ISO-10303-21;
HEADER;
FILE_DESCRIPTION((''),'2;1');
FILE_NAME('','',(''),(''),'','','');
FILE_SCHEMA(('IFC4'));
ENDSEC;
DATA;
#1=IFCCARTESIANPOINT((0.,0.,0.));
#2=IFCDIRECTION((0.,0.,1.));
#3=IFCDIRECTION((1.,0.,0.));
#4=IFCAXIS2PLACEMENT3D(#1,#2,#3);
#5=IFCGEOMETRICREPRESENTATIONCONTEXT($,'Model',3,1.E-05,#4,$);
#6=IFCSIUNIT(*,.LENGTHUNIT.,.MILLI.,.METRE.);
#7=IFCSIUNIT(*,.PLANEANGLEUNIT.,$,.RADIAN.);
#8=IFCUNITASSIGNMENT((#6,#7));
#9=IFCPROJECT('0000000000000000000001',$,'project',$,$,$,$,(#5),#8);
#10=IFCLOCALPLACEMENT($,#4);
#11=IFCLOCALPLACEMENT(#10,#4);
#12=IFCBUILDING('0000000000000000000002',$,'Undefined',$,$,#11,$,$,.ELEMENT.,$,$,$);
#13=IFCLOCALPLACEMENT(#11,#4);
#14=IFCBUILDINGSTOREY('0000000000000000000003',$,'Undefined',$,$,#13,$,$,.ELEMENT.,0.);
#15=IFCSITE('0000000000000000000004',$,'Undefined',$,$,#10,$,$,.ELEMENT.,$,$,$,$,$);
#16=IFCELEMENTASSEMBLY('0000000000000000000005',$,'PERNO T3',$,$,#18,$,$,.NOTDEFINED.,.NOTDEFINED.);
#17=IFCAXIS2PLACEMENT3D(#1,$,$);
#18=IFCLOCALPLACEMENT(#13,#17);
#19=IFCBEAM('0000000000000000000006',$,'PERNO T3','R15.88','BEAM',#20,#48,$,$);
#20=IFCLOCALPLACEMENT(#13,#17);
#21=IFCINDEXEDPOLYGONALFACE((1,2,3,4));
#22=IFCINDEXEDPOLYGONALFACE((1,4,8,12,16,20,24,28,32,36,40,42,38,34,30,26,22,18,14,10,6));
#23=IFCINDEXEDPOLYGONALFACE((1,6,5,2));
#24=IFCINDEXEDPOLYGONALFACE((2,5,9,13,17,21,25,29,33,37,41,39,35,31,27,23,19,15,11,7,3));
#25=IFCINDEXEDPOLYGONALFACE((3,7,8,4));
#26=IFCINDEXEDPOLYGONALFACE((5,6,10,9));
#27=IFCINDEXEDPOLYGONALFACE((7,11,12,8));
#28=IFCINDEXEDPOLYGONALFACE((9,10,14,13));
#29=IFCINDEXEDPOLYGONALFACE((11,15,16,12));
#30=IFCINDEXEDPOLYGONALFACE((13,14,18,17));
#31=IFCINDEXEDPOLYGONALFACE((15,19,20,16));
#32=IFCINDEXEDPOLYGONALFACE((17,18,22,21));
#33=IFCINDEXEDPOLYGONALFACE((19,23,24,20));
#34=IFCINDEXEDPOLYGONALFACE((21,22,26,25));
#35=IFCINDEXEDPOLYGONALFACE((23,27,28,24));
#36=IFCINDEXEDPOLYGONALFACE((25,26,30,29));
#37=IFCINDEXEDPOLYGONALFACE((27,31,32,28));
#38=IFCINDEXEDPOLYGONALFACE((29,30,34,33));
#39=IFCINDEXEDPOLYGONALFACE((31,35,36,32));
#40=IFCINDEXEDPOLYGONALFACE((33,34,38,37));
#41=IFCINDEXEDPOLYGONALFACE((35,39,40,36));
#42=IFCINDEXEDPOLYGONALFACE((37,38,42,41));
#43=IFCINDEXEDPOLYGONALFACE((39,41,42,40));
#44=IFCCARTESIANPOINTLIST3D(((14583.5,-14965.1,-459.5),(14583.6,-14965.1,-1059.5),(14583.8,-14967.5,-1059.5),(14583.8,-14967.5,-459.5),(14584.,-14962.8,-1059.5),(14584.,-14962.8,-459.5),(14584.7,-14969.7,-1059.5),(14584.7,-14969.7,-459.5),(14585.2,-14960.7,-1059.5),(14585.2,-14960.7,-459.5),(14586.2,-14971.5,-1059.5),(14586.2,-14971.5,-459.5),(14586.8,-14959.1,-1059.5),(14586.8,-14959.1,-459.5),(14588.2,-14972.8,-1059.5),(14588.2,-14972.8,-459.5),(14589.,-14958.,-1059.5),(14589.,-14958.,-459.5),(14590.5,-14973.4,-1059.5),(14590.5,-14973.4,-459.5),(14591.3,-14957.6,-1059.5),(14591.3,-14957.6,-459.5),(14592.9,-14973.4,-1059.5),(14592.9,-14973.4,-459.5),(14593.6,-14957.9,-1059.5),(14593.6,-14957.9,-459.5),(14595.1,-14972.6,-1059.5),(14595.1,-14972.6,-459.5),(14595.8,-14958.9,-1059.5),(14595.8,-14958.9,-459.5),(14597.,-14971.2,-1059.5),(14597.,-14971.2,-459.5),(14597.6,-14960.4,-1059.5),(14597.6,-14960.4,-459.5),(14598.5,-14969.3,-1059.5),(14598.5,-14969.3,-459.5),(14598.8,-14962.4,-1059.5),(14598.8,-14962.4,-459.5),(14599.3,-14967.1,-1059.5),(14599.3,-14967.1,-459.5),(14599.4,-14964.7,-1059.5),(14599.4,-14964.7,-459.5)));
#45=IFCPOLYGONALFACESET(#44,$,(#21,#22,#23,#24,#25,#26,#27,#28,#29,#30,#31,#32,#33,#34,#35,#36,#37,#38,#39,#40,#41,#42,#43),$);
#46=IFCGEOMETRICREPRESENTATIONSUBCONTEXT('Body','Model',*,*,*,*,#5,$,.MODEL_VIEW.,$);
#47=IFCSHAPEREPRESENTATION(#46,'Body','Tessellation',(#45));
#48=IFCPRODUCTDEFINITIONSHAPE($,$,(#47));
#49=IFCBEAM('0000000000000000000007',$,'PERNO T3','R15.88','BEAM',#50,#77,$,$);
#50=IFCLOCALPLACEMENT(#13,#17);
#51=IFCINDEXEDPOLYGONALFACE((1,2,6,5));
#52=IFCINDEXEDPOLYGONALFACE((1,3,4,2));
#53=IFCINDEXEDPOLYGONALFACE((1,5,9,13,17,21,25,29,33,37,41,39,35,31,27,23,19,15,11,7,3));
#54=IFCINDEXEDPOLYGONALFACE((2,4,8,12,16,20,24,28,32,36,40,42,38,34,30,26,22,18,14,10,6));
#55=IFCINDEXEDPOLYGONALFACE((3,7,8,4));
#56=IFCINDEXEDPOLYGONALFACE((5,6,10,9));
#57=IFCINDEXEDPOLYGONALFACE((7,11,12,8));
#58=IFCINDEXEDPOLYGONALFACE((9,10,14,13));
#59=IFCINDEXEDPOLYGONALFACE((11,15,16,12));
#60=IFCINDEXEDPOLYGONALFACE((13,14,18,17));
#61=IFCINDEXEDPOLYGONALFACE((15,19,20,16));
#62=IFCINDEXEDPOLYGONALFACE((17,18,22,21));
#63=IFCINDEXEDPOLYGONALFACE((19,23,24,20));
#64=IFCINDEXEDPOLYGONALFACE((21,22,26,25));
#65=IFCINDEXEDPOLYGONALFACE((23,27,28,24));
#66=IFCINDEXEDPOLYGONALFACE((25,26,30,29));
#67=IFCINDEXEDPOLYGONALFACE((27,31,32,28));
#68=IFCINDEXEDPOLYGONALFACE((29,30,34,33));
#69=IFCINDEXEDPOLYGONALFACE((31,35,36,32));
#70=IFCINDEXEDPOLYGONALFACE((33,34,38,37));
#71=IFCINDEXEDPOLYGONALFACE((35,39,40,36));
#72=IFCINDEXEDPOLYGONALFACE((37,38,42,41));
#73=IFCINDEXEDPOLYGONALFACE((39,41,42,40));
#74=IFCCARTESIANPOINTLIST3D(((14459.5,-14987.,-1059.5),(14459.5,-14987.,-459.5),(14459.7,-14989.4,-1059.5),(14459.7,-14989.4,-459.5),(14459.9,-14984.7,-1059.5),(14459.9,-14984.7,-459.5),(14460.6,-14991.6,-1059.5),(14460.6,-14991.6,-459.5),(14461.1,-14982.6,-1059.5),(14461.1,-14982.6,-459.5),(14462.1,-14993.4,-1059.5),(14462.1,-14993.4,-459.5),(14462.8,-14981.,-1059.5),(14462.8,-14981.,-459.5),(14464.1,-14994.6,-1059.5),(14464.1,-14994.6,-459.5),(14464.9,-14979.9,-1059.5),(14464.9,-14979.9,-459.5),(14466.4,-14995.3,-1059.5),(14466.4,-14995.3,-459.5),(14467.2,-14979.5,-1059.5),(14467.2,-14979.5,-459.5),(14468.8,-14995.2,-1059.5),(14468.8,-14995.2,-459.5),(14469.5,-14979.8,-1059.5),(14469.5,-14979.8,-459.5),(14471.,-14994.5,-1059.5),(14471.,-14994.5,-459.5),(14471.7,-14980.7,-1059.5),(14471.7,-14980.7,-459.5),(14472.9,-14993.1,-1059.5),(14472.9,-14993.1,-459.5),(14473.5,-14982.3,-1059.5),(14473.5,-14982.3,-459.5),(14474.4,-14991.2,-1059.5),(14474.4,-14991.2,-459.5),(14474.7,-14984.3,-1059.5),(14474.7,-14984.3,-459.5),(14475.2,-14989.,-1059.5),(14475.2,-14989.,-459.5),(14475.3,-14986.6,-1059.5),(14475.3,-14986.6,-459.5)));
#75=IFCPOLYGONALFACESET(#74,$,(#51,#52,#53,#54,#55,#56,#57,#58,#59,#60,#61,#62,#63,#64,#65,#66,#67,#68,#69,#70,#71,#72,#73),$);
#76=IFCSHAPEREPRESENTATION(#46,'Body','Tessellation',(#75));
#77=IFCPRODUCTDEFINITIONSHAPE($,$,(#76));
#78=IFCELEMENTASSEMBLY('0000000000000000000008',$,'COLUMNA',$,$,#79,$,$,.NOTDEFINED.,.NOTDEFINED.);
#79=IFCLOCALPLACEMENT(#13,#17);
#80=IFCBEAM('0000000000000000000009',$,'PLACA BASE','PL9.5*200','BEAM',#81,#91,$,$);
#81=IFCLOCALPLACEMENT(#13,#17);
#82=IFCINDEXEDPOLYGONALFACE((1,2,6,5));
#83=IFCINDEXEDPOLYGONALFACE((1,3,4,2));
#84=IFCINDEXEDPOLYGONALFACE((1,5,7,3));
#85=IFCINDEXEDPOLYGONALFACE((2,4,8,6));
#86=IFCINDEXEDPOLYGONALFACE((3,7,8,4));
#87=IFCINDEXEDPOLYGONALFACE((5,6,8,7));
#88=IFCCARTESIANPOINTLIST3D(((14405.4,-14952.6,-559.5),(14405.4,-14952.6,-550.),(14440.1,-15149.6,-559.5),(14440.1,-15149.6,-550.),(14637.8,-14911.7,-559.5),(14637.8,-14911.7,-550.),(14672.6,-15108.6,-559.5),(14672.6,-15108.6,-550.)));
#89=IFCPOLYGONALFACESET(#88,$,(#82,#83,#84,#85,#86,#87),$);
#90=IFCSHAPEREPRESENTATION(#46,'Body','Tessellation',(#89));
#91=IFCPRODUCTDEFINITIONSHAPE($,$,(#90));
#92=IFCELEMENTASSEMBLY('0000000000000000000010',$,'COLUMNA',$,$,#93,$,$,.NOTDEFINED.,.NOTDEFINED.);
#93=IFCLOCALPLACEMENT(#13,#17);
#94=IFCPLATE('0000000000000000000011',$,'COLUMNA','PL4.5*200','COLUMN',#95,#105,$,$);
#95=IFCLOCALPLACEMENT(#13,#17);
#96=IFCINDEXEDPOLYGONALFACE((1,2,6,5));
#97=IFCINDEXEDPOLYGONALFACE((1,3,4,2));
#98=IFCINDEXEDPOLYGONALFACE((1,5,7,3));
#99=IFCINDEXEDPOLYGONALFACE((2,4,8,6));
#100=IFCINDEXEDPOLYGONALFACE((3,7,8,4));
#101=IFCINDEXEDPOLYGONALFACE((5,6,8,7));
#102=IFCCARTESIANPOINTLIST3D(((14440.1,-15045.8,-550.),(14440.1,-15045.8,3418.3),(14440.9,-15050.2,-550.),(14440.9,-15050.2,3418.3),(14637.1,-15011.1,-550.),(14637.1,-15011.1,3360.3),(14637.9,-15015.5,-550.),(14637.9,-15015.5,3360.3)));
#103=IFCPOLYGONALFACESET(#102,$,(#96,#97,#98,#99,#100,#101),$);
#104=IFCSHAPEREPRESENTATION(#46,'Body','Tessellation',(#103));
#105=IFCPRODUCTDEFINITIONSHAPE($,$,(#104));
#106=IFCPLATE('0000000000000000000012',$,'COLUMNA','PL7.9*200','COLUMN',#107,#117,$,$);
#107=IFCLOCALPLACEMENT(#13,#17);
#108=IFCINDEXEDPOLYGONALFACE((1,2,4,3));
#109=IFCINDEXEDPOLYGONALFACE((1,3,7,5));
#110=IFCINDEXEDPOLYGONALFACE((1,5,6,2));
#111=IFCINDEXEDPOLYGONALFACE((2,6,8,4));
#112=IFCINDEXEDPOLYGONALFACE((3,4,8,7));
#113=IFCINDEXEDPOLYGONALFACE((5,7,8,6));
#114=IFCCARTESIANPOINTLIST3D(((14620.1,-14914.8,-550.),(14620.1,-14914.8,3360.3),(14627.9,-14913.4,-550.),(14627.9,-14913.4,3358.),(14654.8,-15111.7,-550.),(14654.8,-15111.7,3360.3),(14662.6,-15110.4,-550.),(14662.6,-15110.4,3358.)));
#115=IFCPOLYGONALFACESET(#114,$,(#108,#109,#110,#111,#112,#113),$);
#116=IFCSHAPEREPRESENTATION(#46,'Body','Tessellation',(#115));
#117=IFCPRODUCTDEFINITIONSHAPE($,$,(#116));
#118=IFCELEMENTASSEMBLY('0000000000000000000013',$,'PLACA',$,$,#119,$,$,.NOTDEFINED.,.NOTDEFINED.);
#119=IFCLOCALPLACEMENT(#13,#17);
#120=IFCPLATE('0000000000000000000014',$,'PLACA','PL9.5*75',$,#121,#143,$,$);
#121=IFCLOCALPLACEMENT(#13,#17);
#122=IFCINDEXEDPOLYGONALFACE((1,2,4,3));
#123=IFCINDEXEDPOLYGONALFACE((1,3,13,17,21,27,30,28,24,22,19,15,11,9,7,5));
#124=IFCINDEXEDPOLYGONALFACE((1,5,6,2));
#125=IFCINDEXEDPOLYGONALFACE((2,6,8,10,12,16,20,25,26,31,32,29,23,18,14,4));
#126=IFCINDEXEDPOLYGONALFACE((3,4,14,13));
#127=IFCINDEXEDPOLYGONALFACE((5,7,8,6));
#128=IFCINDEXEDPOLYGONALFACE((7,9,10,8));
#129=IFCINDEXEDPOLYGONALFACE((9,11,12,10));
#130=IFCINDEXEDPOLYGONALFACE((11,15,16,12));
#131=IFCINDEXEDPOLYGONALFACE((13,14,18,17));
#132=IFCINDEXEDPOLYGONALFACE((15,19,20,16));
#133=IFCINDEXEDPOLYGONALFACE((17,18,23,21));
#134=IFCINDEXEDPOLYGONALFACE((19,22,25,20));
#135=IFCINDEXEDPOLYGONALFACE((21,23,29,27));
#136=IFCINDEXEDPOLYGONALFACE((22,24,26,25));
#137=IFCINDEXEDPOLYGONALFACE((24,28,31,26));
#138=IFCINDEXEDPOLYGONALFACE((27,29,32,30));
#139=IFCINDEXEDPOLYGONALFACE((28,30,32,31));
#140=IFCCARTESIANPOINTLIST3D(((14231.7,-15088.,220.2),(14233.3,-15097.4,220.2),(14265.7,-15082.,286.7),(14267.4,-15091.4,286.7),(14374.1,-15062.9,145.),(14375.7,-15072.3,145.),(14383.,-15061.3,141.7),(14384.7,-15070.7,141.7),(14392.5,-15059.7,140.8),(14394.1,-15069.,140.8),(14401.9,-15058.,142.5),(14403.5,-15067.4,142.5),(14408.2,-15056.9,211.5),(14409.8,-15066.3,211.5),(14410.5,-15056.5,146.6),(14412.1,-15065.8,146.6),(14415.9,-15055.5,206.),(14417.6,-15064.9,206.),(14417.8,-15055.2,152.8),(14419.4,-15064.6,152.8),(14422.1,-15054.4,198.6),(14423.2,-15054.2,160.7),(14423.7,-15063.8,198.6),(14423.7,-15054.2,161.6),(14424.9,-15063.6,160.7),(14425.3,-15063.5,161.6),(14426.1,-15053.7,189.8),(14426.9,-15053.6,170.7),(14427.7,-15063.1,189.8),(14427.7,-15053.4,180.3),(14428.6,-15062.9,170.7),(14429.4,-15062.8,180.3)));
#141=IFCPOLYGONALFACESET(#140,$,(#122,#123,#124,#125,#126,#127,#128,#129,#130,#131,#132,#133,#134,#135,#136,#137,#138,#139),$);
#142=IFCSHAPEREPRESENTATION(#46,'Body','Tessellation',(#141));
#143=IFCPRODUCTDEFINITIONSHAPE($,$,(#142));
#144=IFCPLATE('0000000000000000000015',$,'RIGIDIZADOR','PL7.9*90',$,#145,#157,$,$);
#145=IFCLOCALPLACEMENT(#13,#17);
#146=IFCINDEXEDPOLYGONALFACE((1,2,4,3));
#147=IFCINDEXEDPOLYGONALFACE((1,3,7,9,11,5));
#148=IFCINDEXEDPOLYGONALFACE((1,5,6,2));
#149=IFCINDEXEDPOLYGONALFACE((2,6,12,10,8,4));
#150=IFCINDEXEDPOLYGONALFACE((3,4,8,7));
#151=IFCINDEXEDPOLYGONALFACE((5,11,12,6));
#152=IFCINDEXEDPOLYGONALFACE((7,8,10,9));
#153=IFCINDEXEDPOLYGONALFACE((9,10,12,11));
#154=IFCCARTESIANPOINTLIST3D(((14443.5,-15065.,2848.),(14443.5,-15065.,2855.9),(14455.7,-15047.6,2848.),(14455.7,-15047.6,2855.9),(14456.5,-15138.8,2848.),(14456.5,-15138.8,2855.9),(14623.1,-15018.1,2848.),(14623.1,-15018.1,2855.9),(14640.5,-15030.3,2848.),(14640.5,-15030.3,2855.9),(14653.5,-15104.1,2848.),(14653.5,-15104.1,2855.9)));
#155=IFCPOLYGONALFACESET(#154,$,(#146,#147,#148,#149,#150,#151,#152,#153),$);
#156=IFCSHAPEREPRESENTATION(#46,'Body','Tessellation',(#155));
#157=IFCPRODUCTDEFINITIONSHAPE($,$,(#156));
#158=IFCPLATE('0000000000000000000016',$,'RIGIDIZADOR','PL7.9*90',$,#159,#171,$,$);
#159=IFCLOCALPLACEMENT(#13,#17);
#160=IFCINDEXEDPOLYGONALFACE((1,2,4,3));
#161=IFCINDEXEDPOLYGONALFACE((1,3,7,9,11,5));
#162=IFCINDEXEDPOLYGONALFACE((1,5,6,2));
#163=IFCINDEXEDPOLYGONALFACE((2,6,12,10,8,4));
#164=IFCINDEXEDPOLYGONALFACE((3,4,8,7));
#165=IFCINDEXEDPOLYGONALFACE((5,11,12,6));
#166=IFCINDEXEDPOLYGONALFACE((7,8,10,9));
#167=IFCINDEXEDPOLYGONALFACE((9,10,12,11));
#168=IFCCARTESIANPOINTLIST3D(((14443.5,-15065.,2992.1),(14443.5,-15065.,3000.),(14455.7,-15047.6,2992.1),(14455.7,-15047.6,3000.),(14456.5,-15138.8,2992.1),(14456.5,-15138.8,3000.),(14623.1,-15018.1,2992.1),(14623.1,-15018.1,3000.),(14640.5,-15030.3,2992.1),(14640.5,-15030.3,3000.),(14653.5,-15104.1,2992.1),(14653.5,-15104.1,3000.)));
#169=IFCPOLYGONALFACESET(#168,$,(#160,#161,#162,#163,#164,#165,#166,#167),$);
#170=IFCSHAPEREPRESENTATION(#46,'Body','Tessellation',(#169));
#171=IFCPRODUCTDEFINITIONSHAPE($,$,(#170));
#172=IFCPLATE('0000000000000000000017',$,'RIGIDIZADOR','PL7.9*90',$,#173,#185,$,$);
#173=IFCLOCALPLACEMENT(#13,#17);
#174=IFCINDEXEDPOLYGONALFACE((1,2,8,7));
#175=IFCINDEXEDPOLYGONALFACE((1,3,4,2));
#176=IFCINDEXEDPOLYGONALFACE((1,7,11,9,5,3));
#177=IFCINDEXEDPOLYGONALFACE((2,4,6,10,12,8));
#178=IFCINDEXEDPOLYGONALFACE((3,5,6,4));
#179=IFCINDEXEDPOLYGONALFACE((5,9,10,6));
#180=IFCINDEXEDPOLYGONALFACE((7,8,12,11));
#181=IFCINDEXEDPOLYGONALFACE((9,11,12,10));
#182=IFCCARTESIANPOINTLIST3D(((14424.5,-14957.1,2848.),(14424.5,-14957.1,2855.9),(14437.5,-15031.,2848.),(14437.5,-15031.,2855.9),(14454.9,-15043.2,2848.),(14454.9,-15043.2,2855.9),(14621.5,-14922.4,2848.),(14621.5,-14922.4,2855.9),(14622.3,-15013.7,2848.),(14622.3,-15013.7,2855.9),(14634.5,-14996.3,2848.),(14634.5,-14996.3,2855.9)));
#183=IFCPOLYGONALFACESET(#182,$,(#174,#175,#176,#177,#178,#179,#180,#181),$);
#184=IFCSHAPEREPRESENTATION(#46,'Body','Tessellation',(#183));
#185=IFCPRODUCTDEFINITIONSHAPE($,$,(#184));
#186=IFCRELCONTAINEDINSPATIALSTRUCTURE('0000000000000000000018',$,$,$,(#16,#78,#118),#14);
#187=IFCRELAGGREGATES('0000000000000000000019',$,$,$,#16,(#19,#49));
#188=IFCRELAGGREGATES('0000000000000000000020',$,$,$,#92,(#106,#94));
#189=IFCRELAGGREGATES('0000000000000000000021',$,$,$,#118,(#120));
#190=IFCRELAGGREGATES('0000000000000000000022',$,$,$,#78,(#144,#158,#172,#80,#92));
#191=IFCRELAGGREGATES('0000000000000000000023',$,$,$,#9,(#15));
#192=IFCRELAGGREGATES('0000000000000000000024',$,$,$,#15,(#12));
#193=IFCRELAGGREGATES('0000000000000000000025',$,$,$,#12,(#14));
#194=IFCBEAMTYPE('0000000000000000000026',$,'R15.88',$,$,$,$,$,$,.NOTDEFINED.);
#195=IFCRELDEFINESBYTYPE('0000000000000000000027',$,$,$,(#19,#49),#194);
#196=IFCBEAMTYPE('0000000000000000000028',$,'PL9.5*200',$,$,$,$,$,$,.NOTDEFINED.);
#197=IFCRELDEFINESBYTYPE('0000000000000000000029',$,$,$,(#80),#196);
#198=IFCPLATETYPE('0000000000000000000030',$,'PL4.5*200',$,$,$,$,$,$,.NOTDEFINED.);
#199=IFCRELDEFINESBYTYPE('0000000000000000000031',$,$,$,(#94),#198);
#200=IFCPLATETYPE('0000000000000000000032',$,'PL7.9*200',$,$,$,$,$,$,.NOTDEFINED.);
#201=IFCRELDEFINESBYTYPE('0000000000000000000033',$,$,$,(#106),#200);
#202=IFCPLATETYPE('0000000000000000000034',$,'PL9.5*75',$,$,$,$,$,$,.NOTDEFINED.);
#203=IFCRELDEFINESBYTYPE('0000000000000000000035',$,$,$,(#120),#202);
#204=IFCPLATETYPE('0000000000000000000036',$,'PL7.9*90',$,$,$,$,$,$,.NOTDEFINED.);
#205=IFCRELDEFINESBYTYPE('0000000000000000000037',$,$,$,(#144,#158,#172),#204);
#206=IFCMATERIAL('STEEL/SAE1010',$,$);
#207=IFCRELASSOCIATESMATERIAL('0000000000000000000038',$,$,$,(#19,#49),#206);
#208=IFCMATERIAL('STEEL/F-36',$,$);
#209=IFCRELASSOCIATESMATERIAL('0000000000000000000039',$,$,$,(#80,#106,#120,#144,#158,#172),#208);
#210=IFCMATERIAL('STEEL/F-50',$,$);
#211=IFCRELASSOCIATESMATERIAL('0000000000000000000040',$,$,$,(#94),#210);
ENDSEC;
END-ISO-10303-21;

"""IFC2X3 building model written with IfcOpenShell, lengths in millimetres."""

from ifc_helpers import new_model, si_unit, frame, frame_2d, origin_with_axes, origin_2d_with_axis, place, context, subcontext, project, spatial, polyline, circle_curve, parameter, trimmed, segment, composite_curve, rectangle, circle, outline, extrude, clip, halfspace, material, type_object, element, aggregate, save


model = new_model("IFC2X3")

# Units and contexts
model_context = context("Model", 3, precision=1e-05, world=origin_with_axes())
body_context = subcontext(model_context, "Body", "Model", "MODEL_VIEW")
ifc_project = project(units=[si_unit("LENGTHUNIT", "METRE", prefix="MILLI"), si_unit("PLANEANGLEUNIT", "RADIAN")], contexts=[model_context])

# Site, building, storey
site_placement = place(None, origin_with_axes())
site = spatial("IfcSite", under=ifc_project, at=site_placement, Name="Undefined", CompositionType="ELEMENT")
building_placement = place(site_placement, origin_with_axes())
building = spatial("IfcBuilding", under=site, at=building_placement, Name="Undefined", CompositionType="ELEMENT")
storey_placement = place(building_placement, origin_with_axes())
storey = spatial("IfcBuildingStorey", under=building, at=storey_placement, Name="Undefined", CompositionType="ELEMENT", Elevation=0.0)

# Shared definitions
ifc_material_1 = material(Name="STEEL/F-36")

# Element assembly, beams
assembly_1_placement = place(storey_placement, origin_with_axes())
assembly_1 = element("IfcElementAssembly", 1, at=assembly_1_placement, inside=storey, Name="PERNO T3", AssemblyPlace="NOTDEFINED", PredefinedType="NOTDEFINED")
ifc_material_2 = material(Name="STEEL/SAE1010")
beam_type_1 = type_object("IfcBeamType", Name="R15.88", PredefinedType="NOTDEFINED")
beam_1_placement = place(assembly_1_placement, frame((14591.5, -14965.5, -459.5), z_axis=(0.984808, 0.173648, 0.000002), x_axis=(0.000002, 0.0, -1.0)))
beam_1 = element("IfcBeam", 2, at=beam_1_placement, type_object=beam_type_1, material=ifc_material_2, Name="PERNO T3", Description="R15.88", ObjectType="BEAM", context=body_context, shape_type="SweptSolid", body=[
    extrude(circle(Radius=7.9, at=origin_2d_with_axis()), frame((600.0, 0.0, 0.0), z_axis=(-1.0, 0.0, 0.0), x_axis=(0.0, -1.0, 0.0)), (0.0, 0.0, 1.0), 600.0),
])
beam_2_placement = place(assembly_1_placement, frame((14467.4, -14987.4, -459.5), z_axis=(0.984808, 0.173648, 0.000002), x_axis=(0.000002, 0.0, -1.0)))
beam_2 = element("IfcBeam", 3, at=beam_2_placement, type_object=beam_type_1, material=ifc_material_2, Name="PERNO T3", Description="R15.88", ObjectType="BEAM", context=body_context, shape_type="SweptSolid", body=[
    extrude(circle(Radius=7.9, at=origin_2d_with_axis()), frame((600.0, 0.0, 0.0), z_axis=(-1.0, 0.0, 0.0), x_axis=(0.0, -1.0, 0.0)), (0.0, 0.0, 1.0), 600.0),
])
aggregate(assembly_1, [beam_1, beam_2])

# Element assembly, beam
assembly_2_placement = place(storey_placement, origin_with_axes())
assembly_2 = element("IfcElementAssembly", 4, at=assembly_2_placement, inside=storey, Name="COLUMNA", AssemblyPlace="NOTDEFINED", PredefinedType="NOTDEFINED")
beam_type_2 = type_object("IfcBeamType", Name="PL9.5*200", PredefinedType="NOTDEFINED")
beam_3_placement = place(assembly_2_placement, frame((14655.2, -15010.1, -554.8), z_axis=(0.173649, -0.984808, 0.0), x_axis=(-0.984808, -0.173649, 0.0)))
beam_3 = element("IfcBeam", 5, at=beam_3_placement, type_object=beam_type_2, material=ifc_material_1, Name="PLACA BASE", Description="PL9.5*200", ObjectType="BEAM", context=body_context, shape_type="SweptSolid", body=[
    extrude(rectangle(XDim=9.5, YDim=200.0, at=origin_2d_with_axis()), frame((236.0, 0.0, 0.0), z_axis=(-1.0, 0.0, 0.0), x_axis=(0.0, -1.0, 0.0)), (0.0, 0.0, 1.0), 236.0),
])

# Shared definitions
ifc_material_3 = material(Name="STEEL/F-50")

# Element assembly, plates
assembly_3_placement = place(assembly_2_placement, origin_with_axes())
assembly_3 = element("IfcElementAssembly", 6, at=assembly_3_placement, Name="COLUMNA", AssemblyPlace="NOTDEFINED", PredefinedType="NOTDEFINED")
plate_type_1 = type_object("IfcPlateType", Name="PL4.5*200", PredefinedType="NOTDEFINED")
plate_1_placement = place(assembly_3_placement, frame((14539.0, -15030.6, -550.0), z_axis=(0.173648, -0.984808, 0.0), x_axis=(0.0, 0.0, 1.0)))
plate_1 = element("IfcPlate", 7, at=plate_1_placement, type_object=plate_type_1, material=ifc_material_3, Name="COLUMNA", Description="PL4.5*200", ObjectType="COLUMN", context=body_context, shape_type="Clipping", body=[
    clip(extrude(outline(polyline([(0.0, -100.0), (0.0, 100.0), (3968.3, 100.0), (3968.3, -100.0), (0.0, -100.0)])), frame((0.0, 0.0, -2.2), z_axis=(0.0, 0.0, 1.0), x_axis=(1.0, 0.0, 0.0)), (0.0, 0.0, 1.0), 4.5), halfspace(frame((3939.3, 0.0, 0.0), z_axis=(0.960429, -0.278525, 0.0), x_axis=(0.0, 0.000001, -1.0)), False)),
])
plate_type_2 = type_object("IfcPlateType", Name="PL7.9*200", PredefinedType="NOTDEFINED")
plate_2_placement = place(assembly_3_placement, frame((14641.4, -15012.6, -550.0), z_axis=(-0.984808, -0.173648, 0.0), x_axis=(0.0, 0.0, 1.0)))
plate_2 = element("IfcPlate", 8, at=plate_2_placement, type_object=plate_type_2, material=ifc_material_1, Name="COLUMNA", Description="PL7.9*200", ObjectType="COLUMN", context=body_context, shape_type="Clipping", body=[
    clip(extrude(outline(polyline([(0.0, -100.0), (0.0, 100.0), (3910.3, 100.0), (3910.3, -100.0), (0.0, -100.0)])), frame((0.0, 0.0, -4.0), z_axis=(0.0, 0.0, 1.0), x_axis=(1.0, 0.0, 0.0)), (0.0, 0.0, 1.0), 7.9), halfspace(frame((3909.2, 0.0, 0.0), z_axis=(-0.960429, 0.0, 0.278525), x_axis=(0.0, -1.0, -0.000002)), True)),
])
aggregate(assembly_3, [plate_2, plate_1])

# Element assembly, plate
assembly_4_placement = place(storey_placement, origin_with_axes())
assembly_4 = element("IfcElementAssembly", 9, at=assembly_4_placement, inside=storey, Name="PLACA", AssemblyPlace="NOTDEFINED", PredefinedType="NOTDEFINED")
plate_type_3 = type_object("IfcPlateType", Name="PL9.5*75", PredefinedType="NOTDEFINED")
plate_3_placement = place(assembly_4_placement, frame((14441.3, -15055.9, 194.4), z_axis=(-0.173649, 0.984808, 0.0), x_axis=(-0.454344, -0.080114, -0.887217)))
plate_3 = element("IfcPlate", 10, at=plate_3_placement, type_object=plate_type_3, material=ifc_material_1, Name="PLACA", Description="PL9.5*75", context=body_context, shape_type="SweptSolid", body=[
    extrude(outline(composite_curve([segment(trimmed(circle_curve(frame_2d((37.0, 37.0), x_axis=(-1.0, 0.0)), 37.0), [parameter(0.0)], [parameter(1.570796)], True, "PARAMETER"), True, "CONTINUOUS"), segment(polyline([(37.0, 0.0), (38.0, 0.0)]), True, "CONTINUOUS"), segment(trimmed(circle_curve(frame_2d((38.0, 37.0), x_axis=(0.0, -1.0)), 37.0), [parameter(0.0)], [parameter(1.570797)], True, "PARAMETER"), True, "CONTINUOUS"), segment(polyline([(75.0, 37.0), (75.0, 200.0), (0.0, 200.0), (0.0, 37.0)]), True, "CONTINUOUS")], self_intersect=True)), frame((0.0, 0.0, -4.8), z_axis=(0.0, 0.0, 1.0), x_axis=(1.0, 0.0, 0.0)), (0.0, 0.0, 1.0), 9.5),
])
aggregate(assembly_4, [plate_3])

# Plates
plate_type_4 = type_object("IfcPlateType", Name="PL7.9*90", PredefinedType="NOTDEFINED")
plate_4_placement = place(assembly_2_placement, frame((14637.9, -15015.5, 2851.9), z_axis=(0.0, 0.0, -1.0), x_axis=(0.173649, -0.984808, 0.0)))
plate_4 = element("IfcPlate", 11, at=plate_4_placement, type_object=plate_type_4, material=ifc_material_1, Name="RIGIDIZADOR", Description="PL7.9*90", context=body_context, shape_type="SweptSolid", body=[
    extrude(outline(polyline([(0.0, 15.0), (15.0, 0.0), (90.0, 0.0), (90.0, 200.0), (15.0, 200.0), (0.0, 185.0), (0.0, 15.0)])), frame((0.0, 0.0, -4.0), z_axis=(0.0, 0.0, 1.0), x_axis=(1.0, 0.0, 0.0)), (0.0, 0.0, 1.0), 7.9),
])
plate_5_placement = place(assembly_2_placement, frame((14637.9, -15015.5, 2996.1), z_axis=(0.0, 0.0, -1.0), x_axis=(0.173649, -0.984808, 0.0)))
plate_5 = element("IfcPlate", 12, at=plate_5_placement, type_object=plate_type_4, material=ifc_material_1, Name="RIGIDIZADOR", Description="PL7.9*90", context=body_context, shape_type="SweptSolid", body=[
    extrude(outline(polyline([(0.0, 15.0), (15.0, 0.0), (90.0, 0.0), (90.0, 200.0), (15.0, 200.0), (0.0, 185.0), (0.0, 15.0)])), frame((0.0, 0.0, -4.0), z_axis=(0.0, 0.0, 1.0), x_axis=(1.0, 0.0, 0.0)), (0.0, 0.0, 1.0), 7.9),
])
plate_6_placement = place(assembly_2_placement, frame((14637.1, -15011.1, 2851.9), z_axis=(0.0, 0.0, 1.0), x_axis=(-0.173649, 0.984808, 0.0)))
plate_6 = element("IfcPlate", 13, at=plate_6_placement, type_object=plate_type_4, material=ifc_material_1, Name="RIGIDIZADOR", Description="PL7.9*90", context=body_context, shape_type="SweptSolid", body=[
    extrude(outline(polyline([(0.0, 15.0), (15.0, 0.0), (90.0, 0.0), (90.0, 200.0), (15.0, 200.0), (0.0, 185.0), (0.0, 15.0)])), frame((0.0, 0.0, -4.0), z_axis=(0.0, 0.0, 1.0), x_axis=(1.0, 0.0, 0.0)), (0.0, 0.0, 1.0), 7.9),
])

aggregate(assembly_2, [plate_4, plate_5, plate_6, beam_3, assembly_3])

save(model, "model.ifc")
